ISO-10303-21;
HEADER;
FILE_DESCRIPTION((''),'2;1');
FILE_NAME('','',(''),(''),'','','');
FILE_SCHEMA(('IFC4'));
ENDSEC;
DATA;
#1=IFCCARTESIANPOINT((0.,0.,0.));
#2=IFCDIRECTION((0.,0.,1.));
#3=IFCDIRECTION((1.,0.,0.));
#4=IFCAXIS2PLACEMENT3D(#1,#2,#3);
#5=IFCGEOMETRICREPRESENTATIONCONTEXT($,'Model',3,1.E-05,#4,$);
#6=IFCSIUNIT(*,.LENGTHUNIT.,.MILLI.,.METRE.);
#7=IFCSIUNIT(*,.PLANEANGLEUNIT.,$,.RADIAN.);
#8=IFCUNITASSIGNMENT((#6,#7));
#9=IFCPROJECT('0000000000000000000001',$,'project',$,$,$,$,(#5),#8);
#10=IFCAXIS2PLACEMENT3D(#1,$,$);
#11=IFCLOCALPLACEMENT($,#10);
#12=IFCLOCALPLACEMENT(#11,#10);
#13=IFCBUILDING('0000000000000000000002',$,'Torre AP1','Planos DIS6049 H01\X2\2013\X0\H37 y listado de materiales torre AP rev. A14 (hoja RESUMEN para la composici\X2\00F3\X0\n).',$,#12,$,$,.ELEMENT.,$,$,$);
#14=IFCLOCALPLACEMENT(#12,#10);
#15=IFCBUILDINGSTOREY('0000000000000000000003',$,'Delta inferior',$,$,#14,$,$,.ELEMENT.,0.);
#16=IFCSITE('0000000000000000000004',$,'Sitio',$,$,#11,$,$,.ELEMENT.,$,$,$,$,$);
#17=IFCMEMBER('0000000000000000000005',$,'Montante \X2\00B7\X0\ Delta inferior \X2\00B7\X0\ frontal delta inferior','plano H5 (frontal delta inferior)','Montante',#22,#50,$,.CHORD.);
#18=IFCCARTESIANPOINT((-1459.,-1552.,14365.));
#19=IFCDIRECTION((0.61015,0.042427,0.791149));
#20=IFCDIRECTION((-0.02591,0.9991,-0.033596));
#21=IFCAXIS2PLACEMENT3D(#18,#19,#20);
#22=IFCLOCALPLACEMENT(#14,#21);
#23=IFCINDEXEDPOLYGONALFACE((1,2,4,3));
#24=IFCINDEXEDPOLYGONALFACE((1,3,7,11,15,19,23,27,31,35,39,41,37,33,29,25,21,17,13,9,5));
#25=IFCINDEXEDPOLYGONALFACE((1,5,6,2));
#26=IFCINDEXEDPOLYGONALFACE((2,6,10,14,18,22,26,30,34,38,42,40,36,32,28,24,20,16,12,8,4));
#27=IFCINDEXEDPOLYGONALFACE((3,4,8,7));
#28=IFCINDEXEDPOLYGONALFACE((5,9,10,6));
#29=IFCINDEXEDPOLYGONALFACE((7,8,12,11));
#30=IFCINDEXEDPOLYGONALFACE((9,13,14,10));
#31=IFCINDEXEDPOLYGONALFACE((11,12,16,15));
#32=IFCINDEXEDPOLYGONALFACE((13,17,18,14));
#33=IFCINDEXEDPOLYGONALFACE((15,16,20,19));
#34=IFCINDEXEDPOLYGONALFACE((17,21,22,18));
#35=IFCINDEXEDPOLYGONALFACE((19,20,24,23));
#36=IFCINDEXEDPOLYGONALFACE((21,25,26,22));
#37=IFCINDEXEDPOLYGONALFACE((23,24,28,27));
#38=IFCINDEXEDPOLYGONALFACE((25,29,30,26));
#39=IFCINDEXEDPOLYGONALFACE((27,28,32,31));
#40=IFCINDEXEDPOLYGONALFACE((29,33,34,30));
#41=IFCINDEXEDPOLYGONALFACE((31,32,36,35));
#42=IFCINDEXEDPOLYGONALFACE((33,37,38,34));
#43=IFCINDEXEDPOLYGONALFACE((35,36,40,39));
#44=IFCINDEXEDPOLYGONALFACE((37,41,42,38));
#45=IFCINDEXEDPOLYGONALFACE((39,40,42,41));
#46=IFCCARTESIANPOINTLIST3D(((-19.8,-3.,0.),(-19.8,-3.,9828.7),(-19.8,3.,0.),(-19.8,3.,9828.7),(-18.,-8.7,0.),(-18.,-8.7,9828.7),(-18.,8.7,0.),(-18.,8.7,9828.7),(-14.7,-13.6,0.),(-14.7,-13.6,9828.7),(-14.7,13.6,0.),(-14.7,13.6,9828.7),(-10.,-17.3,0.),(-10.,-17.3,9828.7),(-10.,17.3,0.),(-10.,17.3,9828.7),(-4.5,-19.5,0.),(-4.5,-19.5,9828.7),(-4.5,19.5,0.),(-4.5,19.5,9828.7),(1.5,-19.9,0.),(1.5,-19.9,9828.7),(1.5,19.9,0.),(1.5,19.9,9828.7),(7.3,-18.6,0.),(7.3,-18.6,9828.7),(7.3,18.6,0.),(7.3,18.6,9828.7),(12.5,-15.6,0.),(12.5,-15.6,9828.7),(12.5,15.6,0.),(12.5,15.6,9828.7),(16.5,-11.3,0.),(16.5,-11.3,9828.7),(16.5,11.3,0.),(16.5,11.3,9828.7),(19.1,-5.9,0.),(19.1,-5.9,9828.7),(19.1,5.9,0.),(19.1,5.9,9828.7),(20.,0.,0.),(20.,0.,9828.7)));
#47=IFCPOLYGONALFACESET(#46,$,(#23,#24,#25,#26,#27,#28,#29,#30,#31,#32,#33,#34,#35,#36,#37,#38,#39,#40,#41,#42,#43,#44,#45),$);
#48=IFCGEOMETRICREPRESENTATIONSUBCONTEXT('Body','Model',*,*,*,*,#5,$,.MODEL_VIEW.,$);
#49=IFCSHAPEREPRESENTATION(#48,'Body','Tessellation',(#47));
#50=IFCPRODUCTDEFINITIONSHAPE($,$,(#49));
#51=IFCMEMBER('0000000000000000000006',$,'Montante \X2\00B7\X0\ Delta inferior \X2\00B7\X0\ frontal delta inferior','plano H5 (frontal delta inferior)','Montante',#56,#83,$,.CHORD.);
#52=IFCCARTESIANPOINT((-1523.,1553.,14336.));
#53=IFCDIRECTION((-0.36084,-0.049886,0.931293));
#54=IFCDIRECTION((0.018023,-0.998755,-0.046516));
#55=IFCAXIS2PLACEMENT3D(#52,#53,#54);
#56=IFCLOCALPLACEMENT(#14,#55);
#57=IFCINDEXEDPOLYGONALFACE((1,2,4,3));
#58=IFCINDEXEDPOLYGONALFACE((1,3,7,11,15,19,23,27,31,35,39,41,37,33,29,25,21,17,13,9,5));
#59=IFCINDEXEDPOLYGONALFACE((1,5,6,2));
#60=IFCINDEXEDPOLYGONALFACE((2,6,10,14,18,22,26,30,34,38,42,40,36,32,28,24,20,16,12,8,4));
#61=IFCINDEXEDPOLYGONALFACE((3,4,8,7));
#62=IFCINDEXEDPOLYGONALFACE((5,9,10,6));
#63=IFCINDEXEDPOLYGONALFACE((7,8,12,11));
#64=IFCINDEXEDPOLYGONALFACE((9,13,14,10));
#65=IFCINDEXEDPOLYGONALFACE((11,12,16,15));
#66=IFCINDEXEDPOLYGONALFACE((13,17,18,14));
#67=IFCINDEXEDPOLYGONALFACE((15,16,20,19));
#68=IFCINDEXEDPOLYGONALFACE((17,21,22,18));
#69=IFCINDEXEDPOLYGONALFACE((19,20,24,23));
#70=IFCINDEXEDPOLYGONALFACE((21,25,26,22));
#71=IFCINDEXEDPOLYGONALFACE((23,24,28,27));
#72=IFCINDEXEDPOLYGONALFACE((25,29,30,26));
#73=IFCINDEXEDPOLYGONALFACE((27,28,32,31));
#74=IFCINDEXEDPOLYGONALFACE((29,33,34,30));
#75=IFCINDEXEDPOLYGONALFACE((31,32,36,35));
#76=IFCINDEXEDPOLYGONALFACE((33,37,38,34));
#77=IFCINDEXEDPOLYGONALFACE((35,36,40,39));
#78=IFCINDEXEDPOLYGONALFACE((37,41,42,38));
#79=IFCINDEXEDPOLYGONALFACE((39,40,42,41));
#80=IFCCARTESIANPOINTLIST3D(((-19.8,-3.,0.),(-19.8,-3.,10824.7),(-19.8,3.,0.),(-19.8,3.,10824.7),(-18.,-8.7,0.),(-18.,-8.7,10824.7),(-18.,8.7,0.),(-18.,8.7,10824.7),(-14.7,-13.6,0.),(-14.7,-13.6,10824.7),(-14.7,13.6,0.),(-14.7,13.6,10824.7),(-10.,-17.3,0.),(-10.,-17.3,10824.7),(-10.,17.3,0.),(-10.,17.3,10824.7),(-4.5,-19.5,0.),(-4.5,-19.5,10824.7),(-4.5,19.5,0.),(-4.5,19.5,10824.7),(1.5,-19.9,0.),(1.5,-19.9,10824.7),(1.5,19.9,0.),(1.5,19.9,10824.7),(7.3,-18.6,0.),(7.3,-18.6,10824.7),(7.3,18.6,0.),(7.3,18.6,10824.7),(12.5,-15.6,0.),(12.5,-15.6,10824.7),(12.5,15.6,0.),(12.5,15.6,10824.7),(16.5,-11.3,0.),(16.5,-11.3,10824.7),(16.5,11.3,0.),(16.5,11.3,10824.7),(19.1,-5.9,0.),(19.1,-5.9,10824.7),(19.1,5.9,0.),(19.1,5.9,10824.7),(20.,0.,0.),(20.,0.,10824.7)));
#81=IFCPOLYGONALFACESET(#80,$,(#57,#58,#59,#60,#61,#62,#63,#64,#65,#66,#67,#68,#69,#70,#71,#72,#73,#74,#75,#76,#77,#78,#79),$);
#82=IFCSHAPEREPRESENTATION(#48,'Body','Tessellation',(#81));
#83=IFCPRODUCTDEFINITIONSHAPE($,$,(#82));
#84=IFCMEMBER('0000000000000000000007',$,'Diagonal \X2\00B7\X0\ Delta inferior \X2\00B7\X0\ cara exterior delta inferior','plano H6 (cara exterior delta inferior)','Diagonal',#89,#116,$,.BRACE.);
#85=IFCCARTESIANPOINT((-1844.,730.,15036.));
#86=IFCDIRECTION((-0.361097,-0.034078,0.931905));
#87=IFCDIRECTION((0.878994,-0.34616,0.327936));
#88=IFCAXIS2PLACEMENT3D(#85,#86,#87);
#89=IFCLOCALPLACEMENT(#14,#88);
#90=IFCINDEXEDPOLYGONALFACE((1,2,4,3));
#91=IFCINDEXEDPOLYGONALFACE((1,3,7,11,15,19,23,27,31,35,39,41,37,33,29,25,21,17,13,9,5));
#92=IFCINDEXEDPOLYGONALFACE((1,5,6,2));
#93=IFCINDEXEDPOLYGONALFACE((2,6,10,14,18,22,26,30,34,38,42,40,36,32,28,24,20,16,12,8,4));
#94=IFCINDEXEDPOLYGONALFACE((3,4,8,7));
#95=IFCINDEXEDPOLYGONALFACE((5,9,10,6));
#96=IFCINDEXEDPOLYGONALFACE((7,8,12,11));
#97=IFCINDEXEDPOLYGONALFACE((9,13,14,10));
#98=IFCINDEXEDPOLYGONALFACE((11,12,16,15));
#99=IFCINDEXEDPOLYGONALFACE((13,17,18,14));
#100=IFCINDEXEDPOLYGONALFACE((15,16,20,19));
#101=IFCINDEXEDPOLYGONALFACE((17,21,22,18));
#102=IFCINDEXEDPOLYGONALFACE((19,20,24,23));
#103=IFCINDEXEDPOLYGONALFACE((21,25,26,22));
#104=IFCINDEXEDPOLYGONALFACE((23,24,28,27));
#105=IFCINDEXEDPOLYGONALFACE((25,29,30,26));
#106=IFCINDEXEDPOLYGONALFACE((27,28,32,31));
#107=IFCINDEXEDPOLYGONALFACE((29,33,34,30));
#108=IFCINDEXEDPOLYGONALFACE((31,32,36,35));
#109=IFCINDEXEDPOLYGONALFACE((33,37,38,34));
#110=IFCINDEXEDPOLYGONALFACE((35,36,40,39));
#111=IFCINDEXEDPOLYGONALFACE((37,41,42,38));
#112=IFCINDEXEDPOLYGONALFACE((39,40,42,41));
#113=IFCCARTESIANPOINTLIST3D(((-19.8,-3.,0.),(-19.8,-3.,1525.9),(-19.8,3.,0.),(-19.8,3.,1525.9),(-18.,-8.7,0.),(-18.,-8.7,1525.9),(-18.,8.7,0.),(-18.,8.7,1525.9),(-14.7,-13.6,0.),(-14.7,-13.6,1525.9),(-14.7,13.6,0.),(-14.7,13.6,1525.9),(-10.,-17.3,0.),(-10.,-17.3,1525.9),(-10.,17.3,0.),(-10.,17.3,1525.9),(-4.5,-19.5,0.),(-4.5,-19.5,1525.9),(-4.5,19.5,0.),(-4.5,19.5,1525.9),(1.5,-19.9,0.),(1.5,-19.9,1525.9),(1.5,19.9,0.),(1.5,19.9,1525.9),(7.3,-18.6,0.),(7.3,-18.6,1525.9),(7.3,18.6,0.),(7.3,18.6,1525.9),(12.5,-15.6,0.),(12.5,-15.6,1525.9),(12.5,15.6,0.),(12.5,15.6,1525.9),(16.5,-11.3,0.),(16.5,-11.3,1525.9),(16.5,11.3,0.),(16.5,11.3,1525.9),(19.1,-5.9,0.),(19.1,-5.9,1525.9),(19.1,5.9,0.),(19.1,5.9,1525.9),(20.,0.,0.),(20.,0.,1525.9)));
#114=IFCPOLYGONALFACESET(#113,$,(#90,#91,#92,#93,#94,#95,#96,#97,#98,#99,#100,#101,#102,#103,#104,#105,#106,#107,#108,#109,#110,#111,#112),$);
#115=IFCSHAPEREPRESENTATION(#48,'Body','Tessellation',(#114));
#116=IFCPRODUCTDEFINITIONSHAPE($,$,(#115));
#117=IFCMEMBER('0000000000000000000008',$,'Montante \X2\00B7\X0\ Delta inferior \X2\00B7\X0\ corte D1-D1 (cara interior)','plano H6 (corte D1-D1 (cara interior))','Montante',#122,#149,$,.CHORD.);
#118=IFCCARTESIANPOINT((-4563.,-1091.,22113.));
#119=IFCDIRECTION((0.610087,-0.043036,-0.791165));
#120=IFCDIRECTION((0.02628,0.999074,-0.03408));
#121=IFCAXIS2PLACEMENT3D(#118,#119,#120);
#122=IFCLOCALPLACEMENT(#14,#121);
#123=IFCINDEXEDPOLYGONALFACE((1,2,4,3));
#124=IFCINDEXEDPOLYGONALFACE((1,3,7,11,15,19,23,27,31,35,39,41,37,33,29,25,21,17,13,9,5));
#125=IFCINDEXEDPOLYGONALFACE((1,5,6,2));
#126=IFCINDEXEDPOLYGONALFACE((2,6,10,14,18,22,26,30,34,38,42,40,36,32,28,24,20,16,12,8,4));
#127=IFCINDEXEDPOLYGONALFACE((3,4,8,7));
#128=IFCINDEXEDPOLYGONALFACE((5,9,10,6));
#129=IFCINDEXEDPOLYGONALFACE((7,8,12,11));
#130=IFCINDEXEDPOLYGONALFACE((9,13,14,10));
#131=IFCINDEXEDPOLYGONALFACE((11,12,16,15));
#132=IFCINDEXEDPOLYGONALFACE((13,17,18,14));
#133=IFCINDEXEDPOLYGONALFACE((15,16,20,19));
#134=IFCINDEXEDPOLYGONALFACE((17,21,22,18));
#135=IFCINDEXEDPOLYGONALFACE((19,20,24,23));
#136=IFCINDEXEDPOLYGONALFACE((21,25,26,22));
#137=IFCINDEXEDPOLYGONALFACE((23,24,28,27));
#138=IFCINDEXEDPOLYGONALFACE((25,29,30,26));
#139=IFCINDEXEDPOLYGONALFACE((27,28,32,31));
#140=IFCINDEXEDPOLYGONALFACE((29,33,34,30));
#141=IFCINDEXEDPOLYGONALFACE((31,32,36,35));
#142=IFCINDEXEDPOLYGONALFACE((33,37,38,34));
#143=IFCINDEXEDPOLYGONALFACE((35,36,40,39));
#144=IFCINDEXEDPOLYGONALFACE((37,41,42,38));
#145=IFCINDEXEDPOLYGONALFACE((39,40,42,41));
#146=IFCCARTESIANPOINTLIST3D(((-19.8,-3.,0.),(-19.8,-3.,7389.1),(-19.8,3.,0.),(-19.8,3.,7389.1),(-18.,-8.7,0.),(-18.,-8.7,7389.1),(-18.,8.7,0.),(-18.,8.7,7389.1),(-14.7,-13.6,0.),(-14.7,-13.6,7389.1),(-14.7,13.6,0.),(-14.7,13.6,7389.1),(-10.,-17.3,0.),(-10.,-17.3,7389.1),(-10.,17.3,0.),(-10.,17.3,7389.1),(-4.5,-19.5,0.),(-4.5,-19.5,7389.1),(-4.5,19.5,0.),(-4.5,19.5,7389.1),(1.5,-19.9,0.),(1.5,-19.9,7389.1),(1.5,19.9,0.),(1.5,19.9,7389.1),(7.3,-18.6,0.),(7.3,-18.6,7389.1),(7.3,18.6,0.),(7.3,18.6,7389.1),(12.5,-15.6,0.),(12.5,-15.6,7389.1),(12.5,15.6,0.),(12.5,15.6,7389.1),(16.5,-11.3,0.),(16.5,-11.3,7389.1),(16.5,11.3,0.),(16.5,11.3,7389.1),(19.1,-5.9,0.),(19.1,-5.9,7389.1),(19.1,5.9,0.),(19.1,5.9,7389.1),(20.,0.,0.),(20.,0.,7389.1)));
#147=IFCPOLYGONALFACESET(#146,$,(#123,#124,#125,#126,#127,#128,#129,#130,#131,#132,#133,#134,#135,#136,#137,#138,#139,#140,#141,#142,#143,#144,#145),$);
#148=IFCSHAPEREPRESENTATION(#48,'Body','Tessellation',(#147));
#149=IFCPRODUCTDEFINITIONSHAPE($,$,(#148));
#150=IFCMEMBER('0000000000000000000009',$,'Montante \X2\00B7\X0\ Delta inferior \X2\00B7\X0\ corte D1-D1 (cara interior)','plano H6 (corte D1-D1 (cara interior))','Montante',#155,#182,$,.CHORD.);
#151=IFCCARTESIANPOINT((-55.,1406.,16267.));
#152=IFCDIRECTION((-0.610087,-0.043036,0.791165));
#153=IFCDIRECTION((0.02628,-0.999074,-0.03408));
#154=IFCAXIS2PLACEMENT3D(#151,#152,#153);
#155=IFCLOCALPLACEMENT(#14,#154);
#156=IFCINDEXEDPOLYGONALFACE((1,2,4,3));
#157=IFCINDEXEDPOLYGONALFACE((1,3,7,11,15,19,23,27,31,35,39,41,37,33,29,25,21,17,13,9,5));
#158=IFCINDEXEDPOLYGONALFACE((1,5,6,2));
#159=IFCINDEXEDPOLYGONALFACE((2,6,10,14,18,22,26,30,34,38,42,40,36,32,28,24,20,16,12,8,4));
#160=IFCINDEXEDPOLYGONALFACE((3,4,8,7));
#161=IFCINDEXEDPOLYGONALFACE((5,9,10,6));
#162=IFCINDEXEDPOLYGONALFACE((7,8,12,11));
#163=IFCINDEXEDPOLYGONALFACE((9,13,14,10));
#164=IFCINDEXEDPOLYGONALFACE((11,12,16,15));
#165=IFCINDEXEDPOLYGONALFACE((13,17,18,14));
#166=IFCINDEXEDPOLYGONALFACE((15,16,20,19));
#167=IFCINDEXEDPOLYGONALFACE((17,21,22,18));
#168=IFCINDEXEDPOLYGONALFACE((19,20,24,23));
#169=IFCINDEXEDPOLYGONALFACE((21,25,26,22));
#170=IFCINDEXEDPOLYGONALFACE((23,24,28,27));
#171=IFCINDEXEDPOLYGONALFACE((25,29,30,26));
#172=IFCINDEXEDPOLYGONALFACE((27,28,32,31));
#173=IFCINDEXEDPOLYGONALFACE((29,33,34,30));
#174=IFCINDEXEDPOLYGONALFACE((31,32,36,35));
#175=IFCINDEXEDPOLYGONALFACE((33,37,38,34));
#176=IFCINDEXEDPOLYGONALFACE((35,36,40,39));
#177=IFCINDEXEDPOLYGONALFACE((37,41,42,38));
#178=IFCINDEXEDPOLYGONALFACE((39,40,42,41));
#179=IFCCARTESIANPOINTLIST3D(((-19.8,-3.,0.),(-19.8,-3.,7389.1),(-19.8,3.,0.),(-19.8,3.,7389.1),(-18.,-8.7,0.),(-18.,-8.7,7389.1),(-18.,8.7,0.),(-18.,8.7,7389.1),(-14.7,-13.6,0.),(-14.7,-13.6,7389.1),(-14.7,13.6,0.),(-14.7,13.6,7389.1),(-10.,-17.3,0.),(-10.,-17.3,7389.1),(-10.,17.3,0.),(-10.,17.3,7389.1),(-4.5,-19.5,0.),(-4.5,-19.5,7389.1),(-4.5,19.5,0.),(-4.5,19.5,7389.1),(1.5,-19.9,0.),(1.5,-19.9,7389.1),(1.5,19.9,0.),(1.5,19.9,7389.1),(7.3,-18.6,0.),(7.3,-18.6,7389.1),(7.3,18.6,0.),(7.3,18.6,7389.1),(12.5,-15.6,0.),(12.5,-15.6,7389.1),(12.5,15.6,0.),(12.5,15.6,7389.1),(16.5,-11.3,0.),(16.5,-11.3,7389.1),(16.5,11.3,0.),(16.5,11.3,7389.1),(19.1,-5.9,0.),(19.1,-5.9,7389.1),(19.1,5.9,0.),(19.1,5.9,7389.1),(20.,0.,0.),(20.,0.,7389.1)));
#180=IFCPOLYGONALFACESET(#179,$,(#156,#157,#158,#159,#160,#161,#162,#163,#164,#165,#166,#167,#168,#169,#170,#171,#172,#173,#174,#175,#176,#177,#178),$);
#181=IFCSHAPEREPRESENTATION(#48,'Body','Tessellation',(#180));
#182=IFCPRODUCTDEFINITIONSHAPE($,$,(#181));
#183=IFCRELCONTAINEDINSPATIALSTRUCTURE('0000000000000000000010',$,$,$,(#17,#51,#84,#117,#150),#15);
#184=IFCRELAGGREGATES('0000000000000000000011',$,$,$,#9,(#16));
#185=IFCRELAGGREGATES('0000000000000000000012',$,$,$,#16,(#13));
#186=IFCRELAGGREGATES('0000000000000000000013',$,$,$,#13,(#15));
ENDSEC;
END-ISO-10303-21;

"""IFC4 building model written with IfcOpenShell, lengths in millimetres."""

from ifc_helpers import new_model, si_unit, frame, origin, origin_with_axes, place, context, subcontext, project, spatial, circle, extrude, element, save


model = new_model("IFC4")

# Units and contexts
model_context = context("Model", 3, precision=1e-05, world=origin_with_axes())
body_context = subcontext(model_context, "Body", "Model", "MODEL_VIEW")
ifc_project = project(units=[si_unit("LENGTHUNIT", "METRE", prefix="MILLI"), si_unit("PLANEANGLEUNIT", "RADIAN")], contexts=[model_context])

# Site, building, storey
site_placement = place(None, origin())
site = spatial("IfcSite", under=ifc_project, at=site_placement, Name="Sitio", CompositionType="ELEMENT")
building_placement = place(site_placement, origin())
building = spatial("IfcBuilding", under=site, at=building_placement, Name="Torre AP1", Description="Planos DIS6049 H01–H37 y listado de materiales torre AP rev. A14 (hoja RESUMEN para la composición).", CompositionType="ELEMENT")
storey_placement = place(building_placement, origin())
storey = spatial("IfcBuildingStorey", under=building, at=storey_placement, Name="Delta inferior", CompositionType="ELEMENT", Elevation=0.0)

# Members
for number, where, z_axis, x_axis, name in (
    (1, (-1459.0, -1552.0, 14365.0), (0.61015, 0.042427, 0.791149), (-0.02591, 0.9991, -0.033596), "Montante · Delta inferior · frontal delta inferior"),
):
    element("IfcMember", number, at=place(storey_placement, frame(where, z_axis=z_axis, x_axis=x_axis)), inside=storey, Name=name, Description="plano H5 (frontal delta inferior)", ObjectType="Montante", PredefinedType="CHORD", context=body_context, shape_type="SweptSolid", body=[
        extrude(circle(Radius=20.0), None, (0.0, 0.0, 1.0), 9828.7),
    ])
for number, where, z_axis, x_axis, name in (
    (2, (-1523.0, 1553.0, 14336.0), (-0.36084, -0.049886, 0.931293), (0.018023, -0.998755, -0.046516), "Montante · Delta inferior · frontal delta inferior"),
):
    element("IfcMember", number, at=place(storey_placement, frame(where, z_axis=z_axis, x_axis=x_axis)), inside=storey, Name=name, Description="plano H5 (frontal delta inferior)", ObjectType="Montante", PredefinedType="CHORD", context=body_context, shape_type="SweptSolid", body=[
        extrude(circle(Radius=20.0), None, (0.0, 0.0, 1.0), 10824.7),
    ])
member_1_placement = place(storey_placement, frame((-1844.0, 730.0, 15036.0), z_axis=(-0.361097, -0.034078, 0.931905), x_axis=(0.878994, -0.34616, 0.327936)))
element("IfcMember", 3, at=member_1_placement, inside=storey, Name="Diagonal · Delta inferior · cara exterior delta inferior", Description="plano H6 (cara exterior delta inferior)", ObjectType="Diagonal", PredefinedType="BRACE", context=body_context, shape_type="SweptSolid", body=[
    extrude(circle(Radius=20.0), None, (0.0, 0.0, 1.0), 1525.9),
])
member_2_placement = place(storey_placement, frame((-4563.0, -1091.0, 22113.0), z_axis=(0.610087, -0.043036, -0.791165), x_axis=(0.02628, 0.999074, -0.03408)))
element("IfcMember", 4, at=member_2_placement, inside=storey, Name="Montante · Delta inferior · corte D1-D1 (cara interior)", Description="plano H6 (corte D1-D1 (cara interior))", ObjectType="Montante", PredefinedType="CHORD", context=body_context, shape_type="SweptSolid", body=[
    extrude(circle(Radius=20.0), None, (0.0, 0.0, 1.0), 7389.1),
])
for number, where, z_axis, x_axis, name in (
    (5, (-55.0, 1406.0, 16267.0), (-0.610087, -0.043036, 0.791165), (0.02628, -0.999074, -0.03408), "Montante · Delta inferior · corte D1-D1 (cara interior)"),
):
    element("IfcMember", number, at=place(storey_placement, frame(where, z_axis=z_axis, x_axis=x_axis)), inside=storey, Name=name, Description="plano H6 (corte D1-D1 (cara interior))", ObjectType="Montante", PredefinedType="CHORD", context=body_context, shape_type="SweptSolid", body=[
        extrude(circle(Radius=20.0), None, (0.0, 0.0, 1.0), 7389.1),
    ])

save(model, "model.ifc")
